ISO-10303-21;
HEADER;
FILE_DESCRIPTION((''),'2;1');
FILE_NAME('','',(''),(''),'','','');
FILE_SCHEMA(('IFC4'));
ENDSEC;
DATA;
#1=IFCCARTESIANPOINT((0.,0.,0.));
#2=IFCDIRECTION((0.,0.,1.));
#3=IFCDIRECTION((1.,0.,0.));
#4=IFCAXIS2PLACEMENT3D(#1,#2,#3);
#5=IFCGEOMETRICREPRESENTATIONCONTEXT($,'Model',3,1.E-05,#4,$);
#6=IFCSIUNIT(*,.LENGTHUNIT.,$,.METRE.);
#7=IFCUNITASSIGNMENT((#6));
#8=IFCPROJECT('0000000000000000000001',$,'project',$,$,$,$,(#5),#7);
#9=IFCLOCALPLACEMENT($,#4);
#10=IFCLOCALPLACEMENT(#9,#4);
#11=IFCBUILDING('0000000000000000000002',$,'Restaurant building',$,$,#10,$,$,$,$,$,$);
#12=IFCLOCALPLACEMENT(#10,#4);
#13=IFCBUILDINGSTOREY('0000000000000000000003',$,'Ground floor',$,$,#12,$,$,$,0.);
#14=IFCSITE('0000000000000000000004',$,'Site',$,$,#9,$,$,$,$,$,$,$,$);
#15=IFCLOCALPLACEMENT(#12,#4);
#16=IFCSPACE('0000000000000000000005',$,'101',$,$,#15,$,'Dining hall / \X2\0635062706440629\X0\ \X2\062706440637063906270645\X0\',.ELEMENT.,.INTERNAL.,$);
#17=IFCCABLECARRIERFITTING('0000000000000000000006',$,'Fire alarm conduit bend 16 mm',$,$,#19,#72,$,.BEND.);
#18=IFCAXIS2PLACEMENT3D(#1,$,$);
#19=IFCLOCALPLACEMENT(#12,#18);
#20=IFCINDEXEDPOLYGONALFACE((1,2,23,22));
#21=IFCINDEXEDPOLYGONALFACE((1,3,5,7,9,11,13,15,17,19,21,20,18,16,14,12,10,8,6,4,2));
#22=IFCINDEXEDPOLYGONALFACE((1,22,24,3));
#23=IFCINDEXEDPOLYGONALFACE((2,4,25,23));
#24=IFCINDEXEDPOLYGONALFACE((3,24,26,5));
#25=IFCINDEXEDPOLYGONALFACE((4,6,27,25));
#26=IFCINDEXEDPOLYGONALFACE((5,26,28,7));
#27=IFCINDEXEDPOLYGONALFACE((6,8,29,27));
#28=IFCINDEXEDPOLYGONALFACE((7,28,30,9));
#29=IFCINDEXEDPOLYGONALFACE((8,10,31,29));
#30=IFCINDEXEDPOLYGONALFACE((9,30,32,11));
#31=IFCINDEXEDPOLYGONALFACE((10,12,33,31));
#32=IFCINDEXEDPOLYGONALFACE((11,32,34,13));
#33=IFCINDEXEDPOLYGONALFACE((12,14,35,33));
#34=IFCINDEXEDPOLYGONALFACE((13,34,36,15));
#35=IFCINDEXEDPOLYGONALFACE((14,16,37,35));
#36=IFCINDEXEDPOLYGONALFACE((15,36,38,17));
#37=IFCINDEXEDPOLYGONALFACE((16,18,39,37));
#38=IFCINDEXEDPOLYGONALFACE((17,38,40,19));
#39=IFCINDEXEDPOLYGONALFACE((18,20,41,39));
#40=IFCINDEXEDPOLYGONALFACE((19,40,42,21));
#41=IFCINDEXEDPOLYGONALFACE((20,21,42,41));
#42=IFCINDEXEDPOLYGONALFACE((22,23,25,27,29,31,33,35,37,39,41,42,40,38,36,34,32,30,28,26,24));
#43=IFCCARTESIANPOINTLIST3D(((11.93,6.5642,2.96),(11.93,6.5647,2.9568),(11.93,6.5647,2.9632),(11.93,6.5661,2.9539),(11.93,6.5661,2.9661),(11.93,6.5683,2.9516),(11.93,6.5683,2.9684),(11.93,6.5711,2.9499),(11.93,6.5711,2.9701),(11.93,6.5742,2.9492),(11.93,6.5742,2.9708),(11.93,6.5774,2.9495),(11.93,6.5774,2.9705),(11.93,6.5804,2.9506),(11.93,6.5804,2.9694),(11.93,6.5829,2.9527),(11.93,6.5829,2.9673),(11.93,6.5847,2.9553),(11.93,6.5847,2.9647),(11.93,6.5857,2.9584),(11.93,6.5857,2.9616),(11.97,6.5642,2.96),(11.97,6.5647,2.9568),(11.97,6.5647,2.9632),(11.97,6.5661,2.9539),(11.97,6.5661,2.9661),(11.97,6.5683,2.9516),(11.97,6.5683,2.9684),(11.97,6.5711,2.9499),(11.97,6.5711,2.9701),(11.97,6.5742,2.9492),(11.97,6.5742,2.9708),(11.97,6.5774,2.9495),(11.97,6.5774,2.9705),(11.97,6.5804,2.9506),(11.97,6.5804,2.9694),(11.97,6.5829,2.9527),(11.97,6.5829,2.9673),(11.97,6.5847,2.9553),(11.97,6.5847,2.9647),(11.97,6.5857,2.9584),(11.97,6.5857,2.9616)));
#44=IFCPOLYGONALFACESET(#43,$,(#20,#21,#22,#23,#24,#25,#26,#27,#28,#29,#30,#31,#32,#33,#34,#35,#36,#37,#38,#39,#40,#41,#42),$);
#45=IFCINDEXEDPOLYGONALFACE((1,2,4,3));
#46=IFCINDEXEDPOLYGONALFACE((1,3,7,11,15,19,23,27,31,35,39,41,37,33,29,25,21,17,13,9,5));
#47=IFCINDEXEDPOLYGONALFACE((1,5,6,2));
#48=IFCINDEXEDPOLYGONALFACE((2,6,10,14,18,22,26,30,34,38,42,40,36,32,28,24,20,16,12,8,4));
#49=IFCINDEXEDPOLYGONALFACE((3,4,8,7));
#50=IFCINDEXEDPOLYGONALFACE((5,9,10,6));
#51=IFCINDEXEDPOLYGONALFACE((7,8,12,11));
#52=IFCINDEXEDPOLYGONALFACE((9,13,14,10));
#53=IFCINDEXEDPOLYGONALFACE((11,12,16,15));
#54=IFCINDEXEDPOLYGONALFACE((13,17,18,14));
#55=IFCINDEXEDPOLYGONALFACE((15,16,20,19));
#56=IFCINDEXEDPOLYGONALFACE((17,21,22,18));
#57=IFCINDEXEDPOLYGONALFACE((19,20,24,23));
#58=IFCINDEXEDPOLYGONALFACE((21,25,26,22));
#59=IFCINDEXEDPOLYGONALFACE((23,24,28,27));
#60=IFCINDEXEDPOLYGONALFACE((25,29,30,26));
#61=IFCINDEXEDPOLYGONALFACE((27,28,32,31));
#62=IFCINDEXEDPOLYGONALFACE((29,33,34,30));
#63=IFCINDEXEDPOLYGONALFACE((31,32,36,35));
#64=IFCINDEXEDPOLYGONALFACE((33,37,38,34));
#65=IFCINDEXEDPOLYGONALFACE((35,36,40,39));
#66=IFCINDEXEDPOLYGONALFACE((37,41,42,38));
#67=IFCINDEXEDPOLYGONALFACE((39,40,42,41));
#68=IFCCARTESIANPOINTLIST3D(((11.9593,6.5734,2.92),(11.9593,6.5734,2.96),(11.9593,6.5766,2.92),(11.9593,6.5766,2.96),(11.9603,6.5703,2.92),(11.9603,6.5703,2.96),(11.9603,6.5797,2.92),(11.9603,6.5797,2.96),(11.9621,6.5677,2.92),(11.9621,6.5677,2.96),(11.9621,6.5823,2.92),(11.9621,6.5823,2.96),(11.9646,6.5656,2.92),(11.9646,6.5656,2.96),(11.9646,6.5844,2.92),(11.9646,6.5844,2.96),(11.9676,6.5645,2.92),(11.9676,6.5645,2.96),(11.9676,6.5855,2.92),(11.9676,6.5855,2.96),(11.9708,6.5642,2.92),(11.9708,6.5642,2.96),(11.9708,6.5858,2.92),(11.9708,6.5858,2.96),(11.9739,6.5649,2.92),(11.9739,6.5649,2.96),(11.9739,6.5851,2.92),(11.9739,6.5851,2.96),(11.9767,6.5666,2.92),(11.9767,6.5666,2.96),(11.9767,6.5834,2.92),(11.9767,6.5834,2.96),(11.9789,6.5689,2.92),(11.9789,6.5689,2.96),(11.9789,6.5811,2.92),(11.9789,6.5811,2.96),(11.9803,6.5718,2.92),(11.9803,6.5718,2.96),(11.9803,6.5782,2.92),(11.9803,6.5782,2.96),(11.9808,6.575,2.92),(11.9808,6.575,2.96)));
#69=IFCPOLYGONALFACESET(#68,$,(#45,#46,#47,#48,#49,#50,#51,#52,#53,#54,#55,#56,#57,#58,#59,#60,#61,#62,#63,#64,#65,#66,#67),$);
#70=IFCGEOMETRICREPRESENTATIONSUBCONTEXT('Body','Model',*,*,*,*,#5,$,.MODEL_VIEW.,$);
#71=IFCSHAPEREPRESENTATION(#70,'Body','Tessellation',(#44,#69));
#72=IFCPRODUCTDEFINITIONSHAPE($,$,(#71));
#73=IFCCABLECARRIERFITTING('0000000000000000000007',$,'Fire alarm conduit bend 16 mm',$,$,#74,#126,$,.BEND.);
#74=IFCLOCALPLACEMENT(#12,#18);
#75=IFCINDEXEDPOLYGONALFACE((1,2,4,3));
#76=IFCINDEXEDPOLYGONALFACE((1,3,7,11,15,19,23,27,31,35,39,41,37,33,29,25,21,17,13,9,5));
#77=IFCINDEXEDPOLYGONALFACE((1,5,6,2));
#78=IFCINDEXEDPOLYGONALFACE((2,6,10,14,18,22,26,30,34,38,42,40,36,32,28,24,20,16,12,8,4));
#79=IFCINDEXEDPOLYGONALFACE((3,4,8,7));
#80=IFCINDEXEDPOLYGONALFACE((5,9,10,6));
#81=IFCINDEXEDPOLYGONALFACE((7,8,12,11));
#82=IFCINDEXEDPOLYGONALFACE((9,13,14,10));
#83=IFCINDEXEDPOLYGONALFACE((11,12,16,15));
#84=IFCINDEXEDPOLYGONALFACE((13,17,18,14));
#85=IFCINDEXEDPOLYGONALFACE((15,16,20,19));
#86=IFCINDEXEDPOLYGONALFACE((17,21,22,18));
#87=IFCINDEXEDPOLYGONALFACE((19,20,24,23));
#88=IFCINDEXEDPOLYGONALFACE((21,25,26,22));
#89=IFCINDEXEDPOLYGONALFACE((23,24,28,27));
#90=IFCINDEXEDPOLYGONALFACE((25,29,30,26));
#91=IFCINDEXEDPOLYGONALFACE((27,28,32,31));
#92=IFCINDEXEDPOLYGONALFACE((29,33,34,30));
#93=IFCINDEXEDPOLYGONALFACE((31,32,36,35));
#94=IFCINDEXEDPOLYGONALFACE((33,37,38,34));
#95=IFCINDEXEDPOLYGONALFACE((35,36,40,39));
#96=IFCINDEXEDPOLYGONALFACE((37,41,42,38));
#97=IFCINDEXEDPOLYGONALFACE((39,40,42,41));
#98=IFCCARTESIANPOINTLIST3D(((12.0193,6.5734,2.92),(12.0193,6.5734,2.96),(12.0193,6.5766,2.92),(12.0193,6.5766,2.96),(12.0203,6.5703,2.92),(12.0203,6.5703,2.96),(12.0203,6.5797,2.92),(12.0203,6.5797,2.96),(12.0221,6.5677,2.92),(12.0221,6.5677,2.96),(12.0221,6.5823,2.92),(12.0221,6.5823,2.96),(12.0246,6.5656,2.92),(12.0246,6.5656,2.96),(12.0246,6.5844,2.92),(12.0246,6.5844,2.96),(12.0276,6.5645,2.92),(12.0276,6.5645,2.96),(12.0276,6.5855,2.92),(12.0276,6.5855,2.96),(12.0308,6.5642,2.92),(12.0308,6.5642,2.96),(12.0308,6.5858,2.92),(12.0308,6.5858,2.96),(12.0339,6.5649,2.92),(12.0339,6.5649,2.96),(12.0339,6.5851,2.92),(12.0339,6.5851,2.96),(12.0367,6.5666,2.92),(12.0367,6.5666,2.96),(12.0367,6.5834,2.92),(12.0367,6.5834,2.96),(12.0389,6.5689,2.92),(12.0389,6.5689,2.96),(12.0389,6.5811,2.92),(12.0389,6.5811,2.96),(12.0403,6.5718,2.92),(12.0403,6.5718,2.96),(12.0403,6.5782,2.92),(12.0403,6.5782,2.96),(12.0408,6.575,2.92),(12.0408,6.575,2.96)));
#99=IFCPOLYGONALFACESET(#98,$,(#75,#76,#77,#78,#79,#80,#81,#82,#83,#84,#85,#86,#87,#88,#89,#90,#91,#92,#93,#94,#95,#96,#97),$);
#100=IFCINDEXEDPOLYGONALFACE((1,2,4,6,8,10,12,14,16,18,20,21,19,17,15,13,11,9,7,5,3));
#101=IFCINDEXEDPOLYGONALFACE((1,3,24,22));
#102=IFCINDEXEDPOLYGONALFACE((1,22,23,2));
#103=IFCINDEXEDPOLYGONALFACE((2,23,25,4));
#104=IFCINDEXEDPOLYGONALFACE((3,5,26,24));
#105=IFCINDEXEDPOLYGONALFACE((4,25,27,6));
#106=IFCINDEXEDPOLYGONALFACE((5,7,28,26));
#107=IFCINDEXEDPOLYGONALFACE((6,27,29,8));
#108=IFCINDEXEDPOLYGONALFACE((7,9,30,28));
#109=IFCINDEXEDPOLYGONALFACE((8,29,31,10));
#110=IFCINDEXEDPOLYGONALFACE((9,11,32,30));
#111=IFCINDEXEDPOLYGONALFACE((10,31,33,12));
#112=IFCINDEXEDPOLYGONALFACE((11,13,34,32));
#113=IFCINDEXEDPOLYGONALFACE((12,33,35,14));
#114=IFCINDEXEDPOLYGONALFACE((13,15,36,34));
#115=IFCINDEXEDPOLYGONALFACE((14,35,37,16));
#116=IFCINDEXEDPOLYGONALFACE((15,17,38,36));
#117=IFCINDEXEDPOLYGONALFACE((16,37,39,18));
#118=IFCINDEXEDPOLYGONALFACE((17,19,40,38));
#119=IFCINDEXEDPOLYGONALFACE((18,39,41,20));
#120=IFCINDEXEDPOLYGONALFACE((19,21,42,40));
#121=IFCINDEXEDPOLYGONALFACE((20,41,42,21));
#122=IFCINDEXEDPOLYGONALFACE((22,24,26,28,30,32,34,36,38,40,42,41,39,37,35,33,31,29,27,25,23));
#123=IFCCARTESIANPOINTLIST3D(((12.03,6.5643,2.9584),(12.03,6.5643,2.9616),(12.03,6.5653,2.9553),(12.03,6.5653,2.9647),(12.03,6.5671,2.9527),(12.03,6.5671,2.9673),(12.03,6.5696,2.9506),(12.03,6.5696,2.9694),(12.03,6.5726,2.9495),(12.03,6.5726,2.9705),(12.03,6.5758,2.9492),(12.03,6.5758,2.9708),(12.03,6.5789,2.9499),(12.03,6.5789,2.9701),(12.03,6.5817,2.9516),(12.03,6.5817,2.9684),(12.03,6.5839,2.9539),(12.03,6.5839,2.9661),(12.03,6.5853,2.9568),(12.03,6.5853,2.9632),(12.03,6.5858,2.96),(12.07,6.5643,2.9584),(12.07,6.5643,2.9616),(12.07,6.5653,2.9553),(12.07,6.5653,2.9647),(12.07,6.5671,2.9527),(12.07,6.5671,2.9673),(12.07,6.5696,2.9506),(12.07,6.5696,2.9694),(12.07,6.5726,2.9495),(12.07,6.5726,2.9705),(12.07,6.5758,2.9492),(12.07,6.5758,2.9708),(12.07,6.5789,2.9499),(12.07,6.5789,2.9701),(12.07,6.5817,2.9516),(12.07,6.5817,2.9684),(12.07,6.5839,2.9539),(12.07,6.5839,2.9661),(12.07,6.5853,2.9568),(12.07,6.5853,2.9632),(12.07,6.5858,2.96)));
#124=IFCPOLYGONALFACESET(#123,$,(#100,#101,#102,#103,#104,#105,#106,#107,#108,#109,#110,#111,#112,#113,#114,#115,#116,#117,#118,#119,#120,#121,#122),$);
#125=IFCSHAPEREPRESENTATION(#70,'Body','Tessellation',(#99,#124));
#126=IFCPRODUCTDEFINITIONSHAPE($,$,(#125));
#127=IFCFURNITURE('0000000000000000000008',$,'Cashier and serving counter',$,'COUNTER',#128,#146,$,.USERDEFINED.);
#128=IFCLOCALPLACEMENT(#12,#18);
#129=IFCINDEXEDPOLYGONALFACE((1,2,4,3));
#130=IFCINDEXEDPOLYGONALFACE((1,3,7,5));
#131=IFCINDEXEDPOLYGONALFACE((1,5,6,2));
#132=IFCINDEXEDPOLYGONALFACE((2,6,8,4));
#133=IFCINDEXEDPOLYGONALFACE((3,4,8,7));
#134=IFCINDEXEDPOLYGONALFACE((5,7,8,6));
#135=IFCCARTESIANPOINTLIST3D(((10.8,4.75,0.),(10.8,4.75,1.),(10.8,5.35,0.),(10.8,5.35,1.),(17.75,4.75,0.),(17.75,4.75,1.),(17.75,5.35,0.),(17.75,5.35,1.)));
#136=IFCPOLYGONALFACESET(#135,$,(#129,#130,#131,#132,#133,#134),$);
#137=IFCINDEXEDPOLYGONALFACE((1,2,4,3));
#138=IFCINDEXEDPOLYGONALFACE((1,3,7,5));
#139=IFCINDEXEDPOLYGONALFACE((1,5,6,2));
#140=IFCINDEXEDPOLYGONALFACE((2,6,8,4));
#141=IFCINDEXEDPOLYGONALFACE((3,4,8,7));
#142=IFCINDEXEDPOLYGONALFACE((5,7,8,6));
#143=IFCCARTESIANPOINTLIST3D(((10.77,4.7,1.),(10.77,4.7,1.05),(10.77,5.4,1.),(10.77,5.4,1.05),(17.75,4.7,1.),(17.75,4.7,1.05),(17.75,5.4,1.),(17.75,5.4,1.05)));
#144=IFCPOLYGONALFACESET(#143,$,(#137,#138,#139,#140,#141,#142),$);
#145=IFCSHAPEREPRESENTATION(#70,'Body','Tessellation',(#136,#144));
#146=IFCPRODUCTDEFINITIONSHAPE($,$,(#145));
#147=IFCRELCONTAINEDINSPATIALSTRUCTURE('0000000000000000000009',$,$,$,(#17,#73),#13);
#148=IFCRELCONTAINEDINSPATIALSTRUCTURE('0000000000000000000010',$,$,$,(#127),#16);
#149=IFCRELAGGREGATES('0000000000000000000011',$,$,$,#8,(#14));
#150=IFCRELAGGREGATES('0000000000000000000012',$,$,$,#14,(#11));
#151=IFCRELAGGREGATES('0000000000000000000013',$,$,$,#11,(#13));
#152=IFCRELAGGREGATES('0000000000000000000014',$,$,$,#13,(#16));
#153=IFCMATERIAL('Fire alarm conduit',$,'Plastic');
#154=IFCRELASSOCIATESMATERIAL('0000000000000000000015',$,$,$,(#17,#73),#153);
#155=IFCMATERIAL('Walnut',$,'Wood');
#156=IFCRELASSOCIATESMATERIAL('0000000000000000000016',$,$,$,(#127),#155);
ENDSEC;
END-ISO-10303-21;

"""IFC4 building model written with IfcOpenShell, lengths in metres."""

from ifc_helpers import new_model, si_unit, frame, origin_with_axes, origin_2d, place, context, subcontext, project, spatial, rectangle, circle, extrude, material, element, save


model = new_model("IFC4")

# Units and contexts
model_context = context("Model", 3, precision=1e-05, world=origin_with_axes())
body_context = subcontext(model_context, "Body", "Model", "MODEL_VIEW")
ifc_project = project(units=[si_unit("LENGTHUNIT", "METRE")], contexts=[model_context])

# Site, building, storey
site_placement = place(None, origin_with_axes())
site = spatial("IfcSite", under=ifc_project, at=site_placement, Name="Site")
building_placement = place(site_placement, origin_with_axes())
building = spatial("IfcBuilding", under=site, at=building_placement, Name="Restaurant building")
storey_placement = place(building_placement, origin_with_axes())
storey = spatial("IfcBuildingStorey", under=building, at=storey_placement, Name="Ground floor", Elevation=0.0)

# Shared definitions
space_1_placement = place(storey_placement, origin_with_axes())
space_1 = spatial("IfcSpace", under=storey, at=space_1_placement, Name="101", LongName="Dining hall / صالة الطعام", CompositionType="ELEMENT", PredefinedType="INTERNAL")

# Shared definitions
ifc_material_1 = material(Name="Fire alarm conduit", Category="Plastic")

# Cable carrier fittings
cable_carrier_fitting_1_placement = place(storey_placement, frame((11.97, 6.575, 2.96)))
element("IfcCableCarrierFitting", 1, at=cable_carrier_fitting_1_placement, inside=storey, material=ifc_material_1, Name="Fire alarm conduit bend 16 mm", PredefinedType="BEND", context=body_context, shape_type="SweptSolid", body=[
    extrude(circle(Radius=0.0108, at=origin_2d()), frame((0.0, 0.0, 0.0), z_axis=(-1.0, 0.0, 0.0), x_axis=(0.0, -1.0, 0.0)), (0.0, 0.0, 1.0), 0.04),
    extrude(circle(Radius=0.0108, at=origin_2d()), frame((0.0, 0.0, 0.0), z_axis=(0.0, 0.0, -1.0), x_axis=(1.0, 0.0, 0.0)), (0.0, 0.0, 1.0), 0.04),
])
cable_carrier_fitting_2_placement = place(storey_placement, frame((12.03, 6.575, 2.96)))
element("IfcCableCarrierFitting", 2, at=cable_carrier_fitting_2_placement, inside=storey, material=ifc_material_1, Name="Fire alarm conduit bend 16 mm", PredefinedType="BEND", context=body_context, shape_type="SweptSolid", body=[
    extrude(circle(Radius=0.0108, at=origin_2d()), frame((0.0, 0.0, 0.0), z_axis=(0.0, 0.0, -1.0), x_axis=(1.0, 0.0, 0.0)), (0.0, 0.0, 1.0), 0.04),
    extrude(circle(Radius=0.0108, at=origin_2d()), frame((0.0, 0.0, 0.0), z_axis=(1.0, 0.0, 0.0), x_axis=(0.0, 1.0, 0.0)), (0.0, 0.0, 1.0), 0.04),
])

# Furniture
ifc_material_2 = material(Name="Walnut", Category="Wood")
furniture_placement = place(storey_placement, frame((10.8, 4.7, 0.0)))
element("IfcFurniture", 3, at=furniture_placement, inside=space_1, material=ifc_material_2, Name="Cashier and serving counter", ObjectType="COUNTER", PredefinedType="USERDEFINED", context=body_context, shape_type="SweptSolid", body=[
    extrude(rectangle(XDim=6.95, YDim=0.6, at=origin_2d()), frame((3.475, 0.35, 0.0)), (0.0, 0.0, 1.0), 1.0),
    extrude(rectangle(XDim=6.98, YDim=0.7, at=origin_2d()), frame((3.46, 0.35, 1.0)), (0.0, 0.0, 1.0), 0.05),
])

save(model, "model.ifc")
